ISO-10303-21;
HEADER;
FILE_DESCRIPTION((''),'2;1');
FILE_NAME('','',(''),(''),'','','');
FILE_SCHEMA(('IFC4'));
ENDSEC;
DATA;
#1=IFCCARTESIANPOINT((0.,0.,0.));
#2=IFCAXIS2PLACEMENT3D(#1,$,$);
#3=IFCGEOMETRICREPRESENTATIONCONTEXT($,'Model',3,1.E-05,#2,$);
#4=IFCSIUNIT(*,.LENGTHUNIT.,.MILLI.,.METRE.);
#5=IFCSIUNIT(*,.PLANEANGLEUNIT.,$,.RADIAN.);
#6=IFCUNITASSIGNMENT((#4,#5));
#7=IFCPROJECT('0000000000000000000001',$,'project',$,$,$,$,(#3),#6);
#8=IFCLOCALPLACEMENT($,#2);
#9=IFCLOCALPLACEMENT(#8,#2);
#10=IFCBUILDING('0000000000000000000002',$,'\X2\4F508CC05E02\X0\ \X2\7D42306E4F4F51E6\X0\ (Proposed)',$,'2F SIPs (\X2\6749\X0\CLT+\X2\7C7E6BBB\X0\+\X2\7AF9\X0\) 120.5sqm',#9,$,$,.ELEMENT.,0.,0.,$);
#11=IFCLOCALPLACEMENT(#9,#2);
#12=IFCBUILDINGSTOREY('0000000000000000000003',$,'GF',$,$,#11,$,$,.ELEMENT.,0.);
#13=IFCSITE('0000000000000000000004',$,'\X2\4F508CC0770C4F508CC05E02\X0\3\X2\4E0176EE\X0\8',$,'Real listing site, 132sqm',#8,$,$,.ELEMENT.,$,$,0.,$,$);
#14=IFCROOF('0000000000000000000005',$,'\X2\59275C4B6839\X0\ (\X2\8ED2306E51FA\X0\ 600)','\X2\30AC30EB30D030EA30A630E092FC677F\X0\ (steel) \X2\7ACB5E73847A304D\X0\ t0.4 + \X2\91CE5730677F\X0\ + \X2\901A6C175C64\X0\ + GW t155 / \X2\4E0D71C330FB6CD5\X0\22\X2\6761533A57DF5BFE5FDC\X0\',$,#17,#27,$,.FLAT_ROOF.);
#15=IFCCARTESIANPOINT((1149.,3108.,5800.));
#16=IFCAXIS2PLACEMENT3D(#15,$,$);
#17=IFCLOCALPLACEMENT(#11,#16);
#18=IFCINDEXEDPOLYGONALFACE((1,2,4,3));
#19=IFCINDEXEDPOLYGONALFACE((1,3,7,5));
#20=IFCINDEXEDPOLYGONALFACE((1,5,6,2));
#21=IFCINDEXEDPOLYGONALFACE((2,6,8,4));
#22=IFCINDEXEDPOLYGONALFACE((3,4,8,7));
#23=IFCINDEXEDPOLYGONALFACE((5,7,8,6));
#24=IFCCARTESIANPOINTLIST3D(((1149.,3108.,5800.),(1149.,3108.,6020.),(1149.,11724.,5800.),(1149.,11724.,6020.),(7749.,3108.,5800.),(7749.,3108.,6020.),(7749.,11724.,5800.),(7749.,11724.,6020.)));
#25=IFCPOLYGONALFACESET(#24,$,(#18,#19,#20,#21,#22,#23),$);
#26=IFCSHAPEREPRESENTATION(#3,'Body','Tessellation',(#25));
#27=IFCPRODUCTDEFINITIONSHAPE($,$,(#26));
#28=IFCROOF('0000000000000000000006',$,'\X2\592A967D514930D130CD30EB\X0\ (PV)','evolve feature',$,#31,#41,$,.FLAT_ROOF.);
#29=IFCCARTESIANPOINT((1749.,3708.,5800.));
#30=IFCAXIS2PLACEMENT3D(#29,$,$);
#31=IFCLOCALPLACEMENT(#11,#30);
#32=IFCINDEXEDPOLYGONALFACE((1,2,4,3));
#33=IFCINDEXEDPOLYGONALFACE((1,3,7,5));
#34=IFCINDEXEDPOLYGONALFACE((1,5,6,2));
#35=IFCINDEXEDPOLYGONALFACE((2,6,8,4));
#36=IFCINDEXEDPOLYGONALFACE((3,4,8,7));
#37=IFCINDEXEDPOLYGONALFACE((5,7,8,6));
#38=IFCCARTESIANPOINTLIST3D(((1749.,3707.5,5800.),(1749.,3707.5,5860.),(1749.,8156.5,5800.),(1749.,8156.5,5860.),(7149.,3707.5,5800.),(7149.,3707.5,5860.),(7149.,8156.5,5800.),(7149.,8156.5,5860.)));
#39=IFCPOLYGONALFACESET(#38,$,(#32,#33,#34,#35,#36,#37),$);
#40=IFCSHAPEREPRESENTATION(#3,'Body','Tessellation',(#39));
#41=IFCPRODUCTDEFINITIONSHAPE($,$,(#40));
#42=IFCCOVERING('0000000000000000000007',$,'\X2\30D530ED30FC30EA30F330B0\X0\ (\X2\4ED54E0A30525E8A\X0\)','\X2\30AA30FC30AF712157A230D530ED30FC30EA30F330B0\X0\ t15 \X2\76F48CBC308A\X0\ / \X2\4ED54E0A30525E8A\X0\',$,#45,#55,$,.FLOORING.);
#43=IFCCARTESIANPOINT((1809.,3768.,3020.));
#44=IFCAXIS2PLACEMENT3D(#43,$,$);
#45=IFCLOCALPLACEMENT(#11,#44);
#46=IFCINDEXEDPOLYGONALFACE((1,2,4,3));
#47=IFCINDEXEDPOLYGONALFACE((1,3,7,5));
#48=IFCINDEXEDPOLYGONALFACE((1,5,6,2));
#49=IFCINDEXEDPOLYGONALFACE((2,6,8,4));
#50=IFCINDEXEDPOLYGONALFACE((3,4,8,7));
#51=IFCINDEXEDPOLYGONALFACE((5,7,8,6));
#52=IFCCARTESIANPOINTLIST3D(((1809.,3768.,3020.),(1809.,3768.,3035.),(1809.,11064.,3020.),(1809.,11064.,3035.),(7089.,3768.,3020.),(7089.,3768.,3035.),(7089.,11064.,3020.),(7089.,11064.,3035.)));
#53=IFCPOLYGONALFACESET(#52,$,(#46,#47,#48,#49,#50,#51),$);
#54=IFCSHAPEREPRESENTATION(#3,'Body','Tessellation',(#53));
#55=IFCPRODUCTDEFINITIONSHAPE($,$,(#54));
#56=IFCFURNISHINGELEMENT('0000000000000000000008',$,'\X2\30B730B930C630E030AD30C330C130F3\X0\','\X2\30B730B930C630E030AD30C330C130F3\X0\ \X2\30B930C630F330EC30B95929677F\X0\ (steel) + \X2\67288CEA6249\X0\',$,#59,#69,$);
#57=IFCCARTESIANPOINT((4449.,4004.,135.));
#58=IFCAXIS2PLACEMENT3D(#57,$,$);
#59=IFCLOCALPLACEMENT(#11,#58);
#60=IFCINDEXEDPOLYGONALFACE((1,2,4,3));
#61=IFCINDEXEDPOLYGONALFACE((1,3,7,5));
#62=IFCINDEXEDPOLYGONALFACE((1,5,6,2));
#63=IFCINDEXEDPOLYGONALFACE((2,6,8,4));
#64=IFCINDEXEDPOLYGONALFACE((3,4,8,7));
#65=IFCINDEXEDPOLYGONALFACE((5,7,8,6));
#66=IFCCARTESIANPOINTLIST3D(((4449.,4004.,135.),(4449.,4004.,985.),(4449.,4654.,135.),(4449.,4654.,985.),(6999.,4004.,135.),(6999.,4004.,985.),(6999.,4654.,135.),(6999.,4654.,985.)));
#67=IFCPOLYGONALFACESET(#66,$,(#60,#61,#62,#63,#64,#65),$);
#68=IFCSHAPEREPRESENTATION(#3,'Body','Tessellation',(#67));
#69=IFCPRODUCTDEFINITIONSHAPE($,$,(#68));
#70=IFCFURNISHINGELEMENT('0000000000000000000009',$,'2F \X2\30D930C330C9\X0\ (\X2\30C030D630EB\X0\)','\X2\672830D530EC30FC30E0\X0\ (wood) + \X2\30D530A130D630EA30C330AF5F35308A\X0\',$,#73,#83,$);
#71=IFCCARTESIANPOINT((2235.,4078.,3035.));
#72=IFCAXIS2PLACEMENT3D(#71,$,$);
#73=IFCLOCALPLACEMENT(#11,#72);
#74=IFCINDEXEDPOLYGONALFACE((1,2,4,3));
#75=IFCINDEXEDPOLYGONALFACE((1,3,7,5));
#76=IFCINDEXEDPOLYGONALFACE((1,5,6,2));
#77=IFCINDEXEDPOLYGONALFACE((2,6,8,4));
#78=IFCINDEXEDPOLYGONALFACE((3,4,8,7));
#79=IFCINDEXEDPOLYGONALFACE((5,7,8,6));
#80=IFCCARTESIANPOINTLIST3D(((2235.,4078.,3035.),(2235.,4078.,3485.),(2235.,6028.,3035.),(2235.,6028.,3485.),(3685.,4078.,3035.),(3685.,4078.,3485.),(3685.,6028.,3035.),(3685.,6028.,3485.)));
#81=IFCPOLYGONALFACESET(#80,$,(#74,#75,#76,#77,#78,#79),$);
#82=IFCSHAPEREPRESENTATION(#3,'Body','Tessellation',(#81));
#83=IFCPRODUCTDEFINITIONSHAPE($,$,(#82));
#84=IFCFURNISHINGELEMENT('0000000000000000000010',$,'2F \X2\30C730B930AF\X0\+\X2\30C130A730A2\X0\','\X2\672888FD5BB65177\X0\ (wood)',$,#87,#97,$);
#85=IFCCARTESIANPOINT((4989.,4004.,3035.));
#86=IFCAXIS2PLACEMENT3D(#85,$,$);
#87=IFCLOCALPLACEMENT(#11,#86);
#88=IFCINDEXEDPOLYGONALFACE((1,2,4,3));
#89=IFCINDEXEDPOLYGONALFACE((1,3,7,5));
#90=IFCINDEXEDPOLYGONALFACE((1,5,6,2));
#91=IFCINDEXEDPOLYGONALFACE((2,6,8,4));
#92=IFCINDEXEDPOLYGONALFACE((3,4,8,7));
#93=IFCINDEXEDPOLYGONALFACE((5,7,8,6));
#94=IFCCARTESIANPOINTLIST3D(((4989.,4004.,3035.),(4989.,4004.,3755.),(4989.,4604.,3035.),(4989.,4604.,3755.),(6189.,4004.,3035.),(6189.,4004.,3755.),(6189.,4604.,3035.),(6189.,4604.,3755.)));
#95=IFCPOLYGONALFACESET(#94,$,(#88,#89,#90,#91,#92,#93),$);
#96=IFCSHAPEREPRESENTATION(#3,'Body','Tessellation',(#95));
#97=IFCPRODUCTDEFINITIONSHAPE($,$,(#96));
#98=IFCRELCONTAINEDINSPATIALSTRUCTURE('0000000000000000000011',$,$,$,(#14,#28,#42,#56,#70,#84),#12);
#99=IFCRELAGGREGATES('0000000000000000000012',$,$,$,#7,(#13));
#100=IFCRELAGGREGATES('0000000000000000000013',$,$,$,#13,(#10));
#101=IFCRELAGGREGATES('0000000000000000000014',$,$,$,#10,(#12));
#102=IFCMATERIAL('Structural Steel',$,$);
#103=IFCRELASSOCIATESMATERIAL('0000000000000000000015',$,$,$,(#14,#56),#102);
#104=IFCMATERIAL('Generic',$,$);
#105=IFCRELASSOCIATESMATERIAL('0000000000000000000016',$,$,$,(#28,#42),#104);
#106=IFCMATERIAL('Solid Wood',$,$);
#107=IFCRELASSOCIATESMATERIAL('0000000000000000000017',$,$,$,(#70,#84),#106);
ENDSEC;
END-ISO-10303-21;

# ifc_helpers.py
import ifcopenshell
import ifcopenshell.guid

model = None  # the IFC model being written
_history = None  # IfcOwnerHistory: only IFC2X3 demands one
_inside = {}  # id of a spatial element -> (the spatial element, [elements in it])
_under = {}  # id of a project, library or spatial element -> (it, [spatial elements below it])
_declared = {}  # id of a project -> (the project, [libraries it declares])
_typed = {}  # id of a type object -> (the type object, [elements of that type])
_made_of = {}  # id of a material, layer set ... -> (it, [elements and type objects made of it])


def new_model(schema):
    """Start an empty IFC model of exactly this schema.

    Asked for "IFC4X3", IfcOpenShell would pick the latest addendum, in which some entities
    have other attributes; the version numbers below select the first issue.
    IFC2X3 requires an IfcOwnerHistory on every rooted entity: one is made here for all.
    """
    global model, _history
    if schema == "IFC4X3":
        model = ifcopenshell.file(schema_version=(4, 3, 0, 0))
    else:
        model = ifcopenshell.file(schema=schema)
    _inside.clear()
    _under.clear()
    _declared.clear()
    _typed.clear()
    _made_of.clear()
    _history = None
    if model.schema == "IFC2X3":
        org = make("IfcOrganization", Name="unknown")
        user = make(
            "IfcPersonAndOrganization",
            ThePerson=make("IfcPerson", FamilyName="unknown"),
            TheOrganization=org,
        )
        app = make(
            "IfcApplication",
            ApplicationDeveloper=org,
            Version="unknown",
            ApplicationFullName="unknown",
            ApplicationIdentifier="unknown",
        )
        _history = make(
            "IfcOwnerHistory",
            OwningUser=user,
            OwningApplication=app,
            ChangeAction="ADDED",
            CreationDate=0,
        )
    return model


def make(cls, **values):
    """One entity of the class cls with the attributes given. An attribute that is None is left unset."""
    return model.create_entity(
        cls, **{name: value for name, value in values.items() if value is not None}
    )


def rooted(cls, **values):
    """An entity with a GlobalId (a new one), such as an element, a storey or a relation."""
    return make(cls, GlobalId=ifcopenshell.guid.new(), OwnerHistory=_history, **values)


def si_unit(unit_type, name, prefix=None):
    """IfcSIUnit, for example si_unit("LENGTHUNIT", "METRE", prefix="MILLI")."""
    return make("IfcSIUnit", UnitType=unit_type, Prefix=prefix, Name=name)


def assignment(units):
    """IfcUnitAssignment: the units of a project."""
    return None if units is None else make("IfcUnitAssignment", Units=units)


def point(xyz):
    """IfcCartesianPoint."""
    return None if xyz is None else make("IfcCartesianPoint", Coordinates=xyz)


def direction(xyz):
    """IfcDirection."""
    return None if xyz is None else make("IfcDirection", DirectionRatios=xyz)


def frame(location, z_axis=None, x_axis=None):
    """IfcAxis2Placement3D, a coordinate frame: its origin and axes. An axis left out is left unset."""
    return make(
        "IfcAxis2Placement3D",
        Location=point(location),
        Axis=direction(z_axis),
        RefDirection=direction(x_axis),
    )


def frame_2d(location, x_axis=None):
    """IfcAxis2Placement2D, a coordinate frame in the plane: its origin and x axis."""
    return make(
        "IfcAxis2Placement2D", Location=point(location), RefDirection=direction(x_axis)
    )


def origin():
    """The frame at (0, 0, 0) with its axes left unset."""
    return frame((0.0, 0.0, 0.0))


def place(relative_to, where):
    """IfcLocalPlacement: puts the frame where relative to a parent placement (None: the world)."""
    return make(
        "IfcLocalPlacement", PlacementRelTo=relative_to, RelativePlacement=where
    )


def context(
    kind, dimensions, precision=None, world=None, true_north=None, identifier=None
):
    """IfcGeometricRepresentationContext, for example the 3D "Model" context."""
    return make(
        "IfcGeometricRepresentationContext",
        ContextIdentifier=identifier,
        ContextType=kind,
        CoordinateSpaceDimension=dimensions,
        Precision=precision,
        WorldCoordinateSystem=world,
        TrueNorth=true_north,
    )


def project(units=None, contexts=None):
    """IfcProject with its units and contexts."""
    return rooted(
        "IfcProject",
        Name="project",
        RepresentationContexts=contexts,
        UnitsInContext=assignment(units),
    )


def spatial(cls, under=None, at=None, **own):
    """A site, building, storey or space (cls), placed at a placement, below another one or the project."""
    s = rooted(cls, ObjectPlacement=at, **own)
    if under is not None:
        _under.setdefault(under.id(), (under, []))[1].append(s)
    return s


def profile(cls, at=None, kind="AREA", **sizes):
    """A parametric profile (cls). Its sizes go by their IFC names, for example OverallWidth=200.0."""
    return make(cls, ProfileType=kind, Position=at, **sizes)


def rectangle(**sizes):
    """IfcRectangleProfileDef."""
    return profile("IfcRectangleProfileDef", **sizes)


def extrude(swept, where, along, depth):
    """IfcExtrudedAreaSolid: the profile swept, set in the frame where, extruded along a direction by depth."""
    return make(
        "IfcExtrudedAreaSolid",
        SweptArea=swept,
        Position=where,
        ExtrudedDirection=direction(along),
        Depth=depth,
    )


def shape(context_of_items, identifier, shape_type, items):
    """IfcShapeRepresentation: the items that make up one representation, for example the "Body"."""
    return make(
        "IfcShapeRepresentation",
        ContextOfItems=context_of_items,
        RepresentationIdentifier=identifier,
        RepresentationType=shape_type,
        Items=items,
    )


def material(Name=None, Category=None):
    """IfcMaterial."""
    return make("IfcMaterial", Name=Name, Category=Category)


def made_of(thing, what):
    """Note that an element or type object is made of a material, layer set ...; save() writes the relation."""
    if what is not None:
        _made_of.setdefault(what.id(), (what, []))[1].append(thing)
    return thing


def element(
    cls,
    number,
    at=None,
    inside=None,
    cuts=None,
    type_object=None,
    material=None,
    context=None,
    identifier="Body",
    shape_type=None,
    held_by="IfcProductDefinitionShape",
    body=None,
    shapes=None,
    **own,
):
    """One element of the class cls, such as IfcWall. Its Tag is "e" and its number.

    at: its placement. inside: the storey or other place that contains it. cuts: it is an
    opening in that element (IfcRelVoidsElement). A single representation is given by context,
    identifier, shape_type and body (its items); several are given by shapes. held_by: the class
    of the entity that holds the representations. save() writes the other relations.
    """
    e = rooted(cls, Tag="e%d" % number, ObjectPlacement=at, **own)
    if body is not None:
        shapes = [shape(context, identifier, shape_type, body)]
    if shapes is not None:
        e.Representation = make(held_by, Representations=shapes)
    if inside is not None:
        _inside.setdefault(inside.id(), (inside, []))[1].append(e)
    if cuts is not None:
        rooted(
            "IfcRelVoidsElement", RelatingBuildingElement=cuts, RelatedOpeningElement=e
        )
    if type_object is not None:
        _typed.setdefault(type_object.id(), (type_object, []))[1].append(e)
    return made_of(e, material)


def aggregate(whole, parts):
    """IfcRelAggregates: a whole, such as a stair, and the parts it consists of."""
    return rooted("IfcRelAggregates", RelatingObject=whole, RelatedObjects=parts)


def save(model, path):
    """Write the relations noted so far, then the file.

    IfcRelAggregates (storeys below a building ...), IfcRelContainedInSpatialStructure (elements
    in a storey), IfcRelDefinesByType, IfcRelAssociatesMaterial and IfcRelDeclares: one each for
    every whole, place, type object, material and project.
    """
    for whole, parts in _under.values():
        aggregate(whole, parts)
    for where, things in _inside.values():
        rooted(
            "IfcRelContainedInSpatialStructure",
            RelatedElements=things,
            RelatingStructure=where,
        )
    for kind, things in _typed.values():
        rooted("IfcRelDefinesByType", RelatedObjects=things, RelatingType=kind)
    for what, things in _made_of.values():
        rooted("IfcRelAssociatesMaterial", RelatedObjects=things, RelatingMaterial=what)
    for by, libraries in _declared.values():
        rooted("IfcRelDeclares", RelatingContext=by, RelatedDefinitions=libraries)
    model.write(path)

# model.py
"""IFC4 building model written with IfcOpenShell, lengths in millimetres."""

from ifc_helpers import new_model, si_unit, frame, frame_2d, origin, place, context, project, spatial, rectangle, extrude, material, element, save


model = new_model("IFC4")

# Units and contexts
model_context = context("Model", 3, precision=1e-05, world=origin())
ifc_project = project(units=[si_unit("LENGTHUNIT", "METRE", prefix="MILLI"), si_unit("PLANEANGLEUNIT", "RADIAN")], contexts=[model_context])

# Site, building, storey
site_placement = place(None, origin())
site = spatial("IfcSite", under=ifc_project, at=site_placement, Name="佐賀県佐賀市3丁目8", ObjectType="Real listing site, 132sqm", CompositionType="ELEMENT", RefElevation=0.0)
building_placement = place(site_placement, origin())
building = spatial("IfcBuilding", under=site, at=building_placement, Name="佐賀市 終の住処 (Proposed)", ObjectType="2F SIPs (杉CLT+籾殻+竹) 120.5sqm", CompositionType="ELEMENT", ElevationOfRefHeight=0.0, ElevationOfTerrain=0.0)
storey_placement = place(building_placement, origin())
storey = spatial("IfcBuildingStorey", under=building, at=storey_placement, Name="GF", CompositionType="ELEMENT", Elevation=0.0)

# Shared definitions
ifc_material_1 = material(Name="Solid Wood")

# Shared definitions
ifc_material_2 = material(Name="Generic")

# Roofs
ifc_material_3 = material(Name="Structural Steel")
roof_1_placement = place(storey_placement, frame((1149.0, 3108.0, 5800.0)))
element("IfcRoof", 1, at=roof_1_placement, inside=storey, material=ifc_material_3, Name="大屋根 (軒の出 600)", Description="ガルバリウム鋼板 (steel) 立平葺き t0.4 + 野地板 + 通気層 + GW t155 / 不燃・法22条区域対応", PredefinedType="FLAT_ROOF", context=model_context, shape_type="SweptSolid", body=[
    extrude(rectangle(XDim=6600.0, YDim=8616.0, at=frame_2d((3300.0, 4308.0))), frame((1149.0, 3108.0, 5800.0)), (0.0, 0.0, 1.0), 220.0),
])
roof_2_placement = place(storey_placement, frame((1749.0, 3708.0, 5800.0)))
element("IfcRoof", 2, at=roof_2_placement, inside=storey, material=ifc_material_2, Name="太陽光パネル (PV)", Description="evolve feature", PredefinedType="FLAT_ROOF", context=model_context, shape_type="SweptSolid", body=[
    extrude(rectangle(XDim=5400.0, YDim=4449.0, at=frame_2d((2700.0, 2224.0))), frame((1749.0, 3708.0, 5800.0)), (0.0, 0.0, 1.0), 60.0),
])

# Covering
covering_placement = place(storey_placement, frame((1809.0, 3768.0, 3020.0)))
element("IfcCovering", 3, at=covering_placement, inside=storey, material=ifc_material_2, Name="フローリング (仕上げ床)", Description="オーク無垢フローリング t15 直貼り / 仕上げ床", PredefinedType="FLOORING", context=model_context, shape_type="SweptSolid", body=[
    extrude(rectangle(XDim=5280.0, YDim=7296.0, at=frame_2d((2640.0, 3648.0))), frame((1809.0, 3768.0, 3020.0)), (0.0, 0.0, 1.0), 15.0),
])

# Furnishing elements
furnishing_1_placement = place(storey_placement, frame((4449.0, 4004.0, 135.0)))
element("IfcFurnishingElement", 4, at=furnishing_1_placement, inside=storey, material=ifc_material_3, Name="システムキッチン", Description="システムキッチン ステンレス天板 (steel) + 木質扉", context=model_context, shape_type="SweptSolid", body=[
    extrude(rectangle(XDim=2550.0, YDim=650.0, at=frame_2d((1275.0, 325.0))), frame((4449.0, 4004.0, 135.0)), (0.0, 0.0, 1.0), 850.0),
])
furnishing_2_placement = place(storey_placement, frame((2235.0, 4078.0, 3035.0)))
element("IfcFurnishingElement", 5, at=furnishing_2_placement, inside=storey, material=ifc_material_1, Name="2F ベッド (ダブル)", Description="木フレーム (wood) + ファブリック張り", context=model_context, shape_type="SweptSolid", body=[
    extrude(rectangle(XDim=1450.0, YDim=1950.0, at=frame_2d((725.0, 975.0))), frame((2235.0, 4078.0, 3035.0)), (0.0, 0.0, 1.0), 450.0),
])
furnishing_3_placement = place(storey_placement, frame((4989.0, 4004.0, 3035.0)))
element("IfcFurnishingElement", 6, at=furnishing_3_placement, inside=storey, material=ifc_material_1, Name="2F デスク+チェア", Description="木製家具 (wood)", context=model_context, shape_type="SweptSolid", body=[
    extrude(rectangle(XDim=1200.0, YDim=600.0, at=frame_2d((600.0, 300.0))), frame((4989.0, 4004.0, 3035.0)), (0.0, 0.0, 1.0), 720.0),
])

save(model, "model.ifc")
